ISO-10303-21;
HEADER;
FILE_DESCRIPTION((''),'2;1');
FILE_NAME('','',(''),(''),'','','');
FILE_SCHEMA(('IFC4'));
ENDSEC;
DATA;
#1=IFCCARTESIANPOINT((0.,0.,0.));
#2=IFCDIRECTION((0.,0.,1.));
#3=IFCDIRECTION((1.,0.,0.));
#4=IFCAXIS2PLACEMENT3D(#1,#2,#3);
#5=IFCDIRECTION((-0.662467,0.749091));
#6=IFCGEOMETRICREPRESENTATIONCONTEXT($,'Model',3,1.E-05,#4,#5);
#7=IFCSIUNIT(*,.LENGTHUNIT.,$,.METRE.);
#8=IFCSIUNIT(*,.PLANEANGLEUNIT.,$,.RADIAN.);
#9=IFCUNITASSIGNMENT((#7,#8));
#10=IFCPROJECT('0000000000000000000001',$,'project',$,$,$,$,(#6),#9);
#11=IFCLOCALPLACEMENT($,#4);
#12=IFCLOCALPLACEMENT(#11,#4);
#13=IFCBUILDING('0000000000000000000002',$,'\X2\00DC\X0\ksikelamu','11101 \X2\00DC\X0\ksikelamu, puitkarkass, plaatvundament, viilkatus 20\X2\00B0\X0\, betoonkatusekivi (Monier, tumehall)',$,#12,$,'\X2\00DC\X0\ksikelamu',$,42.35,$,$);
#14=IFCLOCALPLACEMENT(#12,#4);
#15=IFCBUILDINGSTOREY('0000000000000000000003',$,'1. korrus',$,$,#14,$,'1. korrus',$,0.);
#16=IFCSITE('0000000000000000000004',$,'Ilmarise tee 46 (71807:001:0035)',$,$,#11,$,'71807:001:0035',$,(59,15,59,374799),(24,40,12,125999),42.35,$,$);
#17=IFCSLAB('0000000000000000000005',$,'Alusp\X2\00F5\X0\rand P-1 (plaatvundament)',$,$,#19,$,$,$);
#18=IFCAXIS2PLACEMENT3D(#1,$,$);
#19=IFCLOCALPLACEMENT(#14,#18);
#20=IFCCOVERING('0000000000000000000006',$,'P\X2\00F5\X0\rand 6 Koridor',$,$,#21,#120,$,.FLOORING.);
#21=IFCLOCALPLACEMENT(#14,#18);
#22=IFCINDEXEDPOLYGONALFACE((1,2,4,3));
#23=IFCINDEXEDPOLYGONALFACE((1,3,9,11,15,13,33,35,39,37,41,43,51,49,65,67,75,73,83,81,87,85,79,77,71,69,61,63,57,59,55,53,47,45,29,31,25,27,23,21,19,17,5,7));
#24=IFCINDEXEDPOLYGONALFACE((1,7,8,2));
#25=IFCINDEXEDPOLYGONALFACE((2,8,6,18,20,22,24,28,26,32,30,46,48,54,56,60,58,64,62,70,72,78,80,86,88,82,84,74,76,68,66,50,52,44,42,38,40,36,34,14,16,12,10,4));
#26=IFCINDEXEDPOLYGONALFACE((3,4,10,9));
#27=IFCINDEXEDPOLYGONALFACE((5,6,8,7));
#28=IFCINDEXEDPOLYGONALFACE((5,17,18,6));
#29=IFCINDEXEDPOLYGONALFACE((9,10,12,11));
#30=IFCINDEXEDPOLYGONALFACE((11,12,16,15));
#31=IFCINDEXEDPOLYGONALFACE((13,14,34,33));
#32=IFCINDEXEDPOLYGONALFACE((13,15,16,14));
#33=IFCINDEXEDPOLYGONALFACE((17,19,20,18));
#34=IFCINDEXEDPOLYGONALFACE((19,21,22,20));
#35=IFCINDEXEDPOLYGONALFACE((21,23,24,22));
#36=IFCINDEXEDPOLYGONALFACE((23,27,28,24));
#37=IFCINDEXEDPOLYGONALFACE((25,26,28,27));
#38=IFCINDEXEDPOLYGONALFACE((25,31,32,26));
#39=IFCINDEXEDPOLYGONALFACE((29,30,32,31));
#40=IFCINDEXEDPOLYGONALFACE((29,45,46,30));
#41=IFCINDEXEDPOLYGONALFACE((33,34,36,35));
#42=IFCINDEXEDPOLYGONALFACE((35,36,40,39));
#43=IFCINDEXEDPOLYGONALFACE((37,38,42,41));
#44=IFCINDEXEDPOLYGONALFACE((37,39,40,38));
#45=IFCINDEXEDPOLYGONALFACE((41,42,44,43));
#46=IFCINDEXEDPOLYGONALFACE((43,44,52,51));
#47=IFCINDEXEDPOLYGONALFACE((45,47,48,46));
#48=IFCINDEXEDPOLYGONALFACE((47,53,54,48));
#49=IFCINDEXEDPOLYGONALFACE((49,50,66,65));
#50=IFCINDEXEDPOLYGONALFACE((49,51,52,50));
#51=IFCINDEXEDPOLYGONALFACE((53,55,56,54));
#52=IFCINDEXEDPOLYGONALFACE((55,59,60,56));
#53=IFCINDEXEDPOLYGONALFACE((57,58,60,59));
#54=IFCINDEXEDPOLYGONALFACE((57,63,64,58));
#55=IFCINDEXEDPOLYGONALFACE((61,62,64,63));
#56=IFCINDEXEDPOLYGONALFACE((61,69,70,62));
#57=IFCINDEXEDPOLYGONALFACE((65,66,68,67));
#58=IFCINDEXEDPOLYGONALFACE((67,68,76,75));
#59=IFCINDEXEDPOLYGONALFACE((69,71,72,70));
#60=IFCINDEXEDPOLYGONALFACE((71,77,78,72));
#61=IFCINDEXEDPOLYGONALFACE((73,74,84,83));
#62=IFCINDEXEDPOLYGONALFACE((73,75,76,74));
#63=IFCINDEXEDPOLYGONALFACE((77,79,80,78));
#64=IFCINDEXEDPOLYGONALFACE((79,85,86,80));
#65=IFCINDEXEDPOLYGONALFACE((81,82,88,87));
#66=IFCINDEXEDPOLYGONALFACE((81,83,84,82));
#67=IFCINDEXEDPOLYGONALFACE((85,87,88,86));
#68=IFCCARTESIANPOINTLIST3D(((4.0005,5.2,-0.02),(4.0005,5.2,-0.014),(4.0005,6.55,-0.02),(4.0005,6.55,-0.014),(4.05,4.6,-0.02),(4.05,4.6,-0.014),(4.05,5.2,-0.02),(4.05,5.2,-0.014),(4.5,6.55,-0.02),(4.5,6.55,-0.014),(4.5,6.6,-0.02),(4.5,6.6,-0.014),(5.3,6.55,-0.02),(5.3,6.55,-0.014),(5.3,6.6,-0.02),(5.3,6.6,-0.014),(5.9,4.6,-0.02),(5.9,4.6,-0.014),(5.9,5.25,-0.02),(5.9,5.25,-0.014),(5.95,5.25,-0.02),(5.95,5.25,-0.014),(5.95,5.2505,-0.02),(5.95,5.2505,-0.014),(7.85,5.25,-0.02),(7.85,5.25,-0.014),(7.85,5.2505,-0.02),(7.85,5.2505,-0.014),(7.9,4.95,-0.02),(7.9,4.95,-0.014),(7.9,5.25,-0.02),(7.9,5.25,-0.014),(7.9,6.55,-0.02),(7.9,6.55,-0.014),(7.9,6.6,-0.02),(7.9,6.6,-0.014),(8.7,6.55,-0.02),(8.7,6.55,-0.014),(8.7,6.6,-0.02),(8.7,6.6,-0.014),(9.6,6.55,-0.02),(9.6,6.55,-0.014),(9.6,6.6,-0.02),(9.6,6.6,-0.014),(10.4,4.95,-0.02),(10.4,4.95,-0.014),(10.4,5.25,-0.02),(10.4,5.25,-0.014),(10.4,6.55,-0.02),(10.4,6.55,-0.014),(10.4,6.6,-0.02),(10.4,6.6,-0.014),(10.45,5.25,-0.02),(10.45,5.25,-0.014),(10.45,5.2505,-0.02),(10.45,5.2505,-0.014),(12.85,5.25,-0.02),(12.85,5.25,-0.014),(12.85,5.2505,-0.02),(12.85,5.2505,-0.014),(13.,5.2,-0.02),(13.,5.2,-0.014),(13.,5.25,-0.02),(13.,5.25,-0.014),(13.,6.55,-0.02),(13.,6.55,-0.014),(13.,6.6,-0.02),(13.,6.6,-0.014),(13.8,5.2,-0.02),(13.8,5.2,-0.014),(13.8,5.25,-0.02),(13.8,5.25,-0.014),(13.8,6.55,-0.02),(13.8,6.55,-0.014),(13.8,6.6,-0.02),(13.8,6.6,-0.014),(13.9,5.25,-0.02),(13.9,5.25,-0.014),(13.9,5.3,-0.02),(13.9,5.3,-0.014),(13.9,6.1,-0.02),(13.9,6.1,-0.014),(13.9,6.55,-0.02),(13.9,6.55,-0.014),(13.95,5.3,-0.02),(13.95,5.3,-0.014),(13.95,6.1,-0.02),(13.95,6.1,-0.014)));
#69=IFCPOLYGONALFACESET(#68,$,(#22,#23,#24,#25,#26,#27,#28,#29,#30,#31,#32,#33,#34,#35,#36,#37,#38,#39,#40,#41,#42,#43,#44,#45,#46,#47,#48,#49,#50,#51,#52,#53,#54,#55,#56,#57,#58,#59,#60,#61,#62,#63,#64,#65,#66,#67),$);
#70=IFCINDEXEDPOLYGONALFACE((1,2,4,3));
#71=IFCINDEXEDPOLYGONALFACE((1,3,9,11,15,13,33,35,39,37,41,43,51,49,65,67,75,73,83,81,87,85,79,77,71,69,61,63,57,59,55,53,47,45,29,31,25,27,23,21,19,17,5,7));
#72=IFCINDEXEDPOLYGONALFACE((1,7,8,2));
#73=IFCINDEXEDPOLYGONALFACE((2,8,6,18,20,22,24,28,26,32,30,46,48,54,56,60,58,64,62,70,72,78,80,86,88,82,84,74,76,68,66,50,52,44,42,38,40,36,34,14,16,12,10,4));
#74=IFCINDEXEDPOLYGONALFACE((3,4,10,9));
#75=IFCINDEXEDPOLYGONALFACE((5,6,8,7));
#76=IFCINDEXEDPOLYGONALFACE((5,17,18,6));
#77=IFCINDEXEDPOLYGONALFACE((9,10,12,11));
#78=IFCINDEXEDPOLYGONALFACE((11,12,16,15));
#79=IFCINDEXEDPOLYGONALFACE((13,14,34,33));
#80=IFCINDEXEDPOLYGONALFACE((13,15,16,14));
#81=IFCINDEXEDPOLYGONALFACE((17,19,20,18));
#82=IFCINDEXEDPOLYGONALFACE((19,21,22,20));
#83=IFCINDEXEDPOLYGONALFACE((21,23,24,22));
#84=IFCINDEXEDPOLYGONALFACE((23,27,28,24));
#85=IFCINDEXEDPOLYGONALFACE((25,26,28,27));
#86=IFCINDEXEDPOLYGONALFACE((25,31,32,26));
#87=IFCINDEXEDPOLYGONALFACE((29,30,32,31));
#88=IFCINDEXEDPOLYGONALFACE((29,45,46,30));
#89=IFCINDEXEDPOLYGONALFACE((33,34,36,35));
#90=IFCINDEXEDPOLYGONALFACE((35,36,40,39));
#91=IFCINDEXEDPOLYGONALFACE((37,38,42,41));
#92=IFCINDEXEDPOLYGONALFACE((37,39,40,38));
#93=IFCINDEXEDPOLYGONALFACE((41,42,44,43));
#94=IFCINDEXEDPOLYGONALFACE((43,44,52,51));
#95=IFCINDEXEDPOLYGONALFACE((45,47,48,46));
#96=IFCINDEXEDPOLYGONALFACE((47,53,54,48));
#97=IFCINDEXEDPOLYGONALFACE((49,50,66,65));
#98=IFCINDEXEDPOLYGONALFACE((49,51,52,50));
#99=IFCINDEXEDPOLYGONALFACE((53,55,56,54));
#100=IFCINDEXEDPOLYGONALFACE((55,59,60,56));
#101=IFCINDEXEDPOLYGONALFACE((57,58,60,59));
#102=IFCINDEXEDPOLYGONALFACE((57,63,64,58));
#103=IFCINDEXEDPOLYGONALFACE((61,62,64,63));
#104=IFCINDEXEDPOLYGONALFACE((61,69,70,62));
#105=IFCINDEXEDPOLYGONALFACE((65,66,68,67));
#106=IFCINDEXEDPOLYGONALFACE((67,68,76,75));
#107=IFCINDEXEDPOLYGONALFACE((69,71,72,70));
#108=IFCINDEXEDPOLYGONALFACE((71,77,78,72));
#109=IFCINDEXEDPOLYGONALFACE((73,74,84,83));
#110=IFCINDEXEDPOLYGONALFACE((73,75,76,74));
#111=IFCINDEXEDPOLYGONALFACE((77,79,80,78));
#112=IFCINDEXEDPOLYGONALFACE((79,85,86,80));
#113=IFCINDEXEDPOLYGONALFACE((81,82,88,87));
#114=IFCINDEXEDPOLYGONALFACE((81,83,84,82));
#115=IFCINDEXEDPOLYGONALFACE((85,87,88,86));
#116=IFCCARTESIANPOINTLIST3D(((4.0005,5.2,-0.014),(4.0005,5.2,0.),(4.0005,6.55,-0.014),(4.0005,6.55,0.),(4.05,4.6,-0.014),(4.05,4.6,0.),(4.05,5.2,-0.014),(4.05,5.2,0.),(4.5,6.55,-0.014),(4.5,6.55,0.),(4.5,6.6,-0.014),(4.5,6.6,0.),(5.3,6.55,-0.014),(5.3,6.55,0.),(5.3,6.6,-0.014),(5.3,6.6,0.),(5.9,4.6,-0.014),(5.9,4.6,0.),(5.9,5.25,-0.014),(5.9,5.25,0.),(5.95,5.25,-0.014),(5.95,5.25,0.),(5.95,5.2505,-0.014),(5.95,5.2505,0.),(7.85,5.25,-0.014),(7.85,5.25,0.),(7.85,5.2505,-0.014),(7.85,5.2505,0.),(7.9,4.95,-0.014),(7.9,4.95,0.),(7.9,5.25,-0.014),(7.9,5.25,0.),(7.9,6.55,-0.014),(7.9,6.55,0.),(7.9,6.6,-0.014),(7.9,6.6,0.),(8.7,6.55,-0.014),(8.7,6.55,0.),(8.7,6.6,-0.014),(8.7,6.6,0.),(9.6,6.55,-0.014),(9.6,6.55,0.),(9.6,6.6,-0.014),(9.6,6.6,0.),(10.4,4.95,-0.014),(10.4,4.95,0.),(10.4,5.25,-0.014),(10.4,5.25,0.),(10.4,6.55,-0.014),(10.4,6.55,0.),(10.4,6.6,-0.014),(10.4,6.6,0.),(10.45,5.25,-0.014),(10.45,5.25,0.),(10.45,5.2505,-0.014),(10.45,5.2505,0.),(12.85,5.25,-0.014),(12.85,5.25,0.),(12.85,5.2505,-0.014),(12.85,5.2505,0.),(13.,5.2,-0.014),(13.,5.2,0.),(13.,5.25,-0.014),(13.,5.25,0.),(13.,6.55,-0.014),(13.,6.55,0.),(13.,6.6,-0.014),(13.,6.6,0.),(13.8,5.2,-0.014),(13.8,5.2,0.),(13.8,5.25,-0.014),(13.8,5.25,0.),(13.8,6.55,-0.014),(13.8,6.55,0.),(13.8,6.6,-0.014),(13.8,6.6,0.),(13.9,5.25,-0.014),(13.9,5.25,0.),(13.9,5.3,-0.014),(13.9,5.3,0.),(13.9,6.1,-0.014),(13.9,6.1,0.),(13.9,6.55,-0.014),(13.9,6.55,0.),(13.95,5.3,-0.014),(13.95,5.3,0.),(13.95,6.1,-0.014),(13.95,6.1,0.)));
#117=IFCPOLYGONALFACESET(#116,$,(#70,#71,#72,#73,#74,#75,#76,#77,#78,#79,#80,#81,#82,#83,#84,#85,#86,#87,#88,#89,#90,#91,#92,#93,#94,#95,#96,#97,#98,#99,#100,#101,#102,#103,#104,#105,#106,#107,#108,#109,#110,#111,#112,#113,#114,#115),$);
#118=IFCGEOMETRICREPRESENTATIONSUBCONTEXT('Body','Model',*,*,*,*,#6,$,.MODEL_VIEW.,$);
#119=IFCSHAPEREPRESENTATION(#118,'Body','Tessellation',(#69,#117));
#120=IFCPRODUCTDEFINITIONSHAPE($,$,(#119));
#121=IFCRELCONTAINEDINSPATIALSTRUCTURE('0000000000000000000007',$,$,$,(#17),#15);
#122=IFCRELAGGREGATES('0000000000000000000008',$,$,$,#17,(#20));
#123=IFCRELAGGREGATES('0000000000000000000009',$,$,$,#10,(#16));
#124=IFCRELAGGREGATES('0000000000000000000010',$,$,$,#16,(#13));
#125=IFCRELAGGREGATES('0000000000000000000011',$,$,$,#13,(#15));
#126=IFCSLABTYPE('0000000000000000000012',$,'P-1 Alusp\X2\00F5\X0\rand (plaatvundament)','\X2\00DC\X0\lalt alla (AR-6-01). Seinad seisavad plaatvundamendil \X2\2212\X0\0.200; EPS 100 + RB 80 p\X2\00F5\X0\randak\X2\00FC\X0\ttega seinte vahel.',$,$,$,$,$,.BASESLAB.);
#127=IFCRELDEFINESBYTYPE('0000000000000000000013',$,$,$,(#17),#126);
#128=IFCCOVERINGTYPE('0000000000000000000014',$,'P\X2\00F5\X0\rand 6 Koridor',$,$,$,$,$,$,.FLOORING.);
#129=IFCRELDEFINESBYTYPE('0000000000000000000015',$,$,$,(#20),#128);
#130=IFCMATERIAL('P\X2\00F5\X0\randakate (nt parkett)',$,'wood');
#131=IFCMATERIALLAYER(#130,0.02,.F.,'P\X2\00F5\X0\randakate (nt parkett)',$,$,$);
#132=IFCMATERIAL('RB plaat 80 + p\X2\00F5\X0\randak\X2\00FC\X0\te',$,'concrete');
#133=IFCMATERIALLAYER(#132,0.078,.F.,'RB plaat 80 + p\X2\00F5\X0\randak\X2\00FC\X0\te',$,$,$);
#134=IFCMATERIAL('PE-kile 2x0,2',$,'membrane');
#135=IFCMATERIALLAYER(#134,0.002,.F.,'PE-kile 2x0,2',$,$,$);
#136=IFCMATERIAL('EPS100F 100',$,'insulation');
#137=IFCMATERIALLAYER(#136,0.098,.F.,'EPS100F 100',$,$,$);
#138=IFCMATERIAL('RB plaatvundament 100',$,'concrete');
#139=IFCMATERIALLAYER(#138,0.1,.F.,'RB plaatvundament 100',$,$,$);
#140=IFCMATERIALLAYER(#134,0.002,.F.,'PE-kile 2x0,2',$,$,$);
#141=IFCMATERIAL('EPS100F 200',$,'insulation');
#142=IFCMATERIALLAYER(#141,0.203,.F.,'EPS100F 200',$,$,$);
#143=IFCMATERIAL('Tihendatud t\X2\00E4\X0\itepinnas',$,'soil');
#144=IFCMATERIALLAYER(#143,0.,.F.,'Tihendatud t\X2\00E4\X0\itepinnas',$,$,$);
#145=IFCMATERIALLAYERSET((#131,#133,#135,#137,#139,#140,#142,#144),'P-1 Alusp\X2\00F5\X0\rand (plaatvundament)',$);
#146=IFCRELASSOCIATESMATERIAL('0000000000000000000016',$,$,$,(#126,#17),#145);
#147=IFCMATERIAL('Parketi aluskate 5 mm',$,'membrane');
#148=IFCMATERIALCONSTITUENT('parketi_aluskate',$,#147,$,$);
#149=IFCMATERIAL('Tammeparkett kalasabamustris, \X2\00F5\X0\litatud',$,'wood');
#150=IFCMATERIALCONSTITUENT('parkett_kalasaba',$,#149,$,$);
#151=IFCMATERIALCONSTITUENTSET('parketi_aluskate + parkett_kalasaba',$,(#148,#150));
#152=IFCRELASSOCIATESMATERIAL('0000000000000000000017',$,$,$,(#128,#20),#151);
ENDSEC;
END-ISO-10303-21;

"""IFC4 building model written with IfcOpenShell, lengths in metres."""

from ifc_helpers import new_model, si_unit, direction, frame, origin_with_axes, place, context, subcontext, project, spatial, indexed_curve, outline, extrude, material, layer, layer_set, layer_usage, constituent, constituent_set, type_object, element, aggregate, save


model = new_model("IFC4")

# Units and contexts
model_context = context("Model", 3, precision=1e-05, world=origin_with_axes(), true_north=direction((-0.662467, 0.749091)))
body_context = subcontext(model_context, "Body", "Model", "MODEL_VIEW")
ifc_project = project(units=[si_unit("LENGTHUNIT", "METRE"), si_unit("PLANEANGLEUNIT", "RADIAN")], contexts=[model_context])

# Site, building, storey
site_placement = place(None, origin_with_axes())
site = spatial("IfcSite", under=ifc_project, at=site_placement, Name="Ilmarise tee 46 (71807:001:0035)", LongName="71807:001:0035", RefLatitude=(59, 15, 59, 374799), RefLongitude=(24, 40, 12, 125999), RefElevation=42.35)
building_placement = place(site_placement, origin_with_axes())
building = spatial("IfcBuilding", under=site, at=building_placement, Name="Üksikelamu", Description="11101 Üksikelamu, puitkarkass, plaatvundament, viilkatus 20°, betoonkatusekivi (Monier, tumehall)", LongName="Üksikelamu", ElevationOfRefHeight=42.35)
storey_placement = place(building_placement, origin_with_axes())
storey = spatial("IfcBuildingStorey", under=building, at=storey_placement, Name="1. korrus", LongName="1. korrus", Elevation=0.0)

# Slab
ifc_material_1 = material(Name="Põrandakate (nt parkett)", Category="wood")
ifc_layer_1 = layer(ifc_material_1, 0.02, ventilated=False, Name="Põrandakate (nt parkett)")
ifc_material_2 = material(Name="RB plaat 80 + põrandaküte", Category="concrete")
ifc_layer_2 = layer(ifc_material_2, 0.078, ventilated=False, Name="RB plaat 80 + põrandaküte")
ifc_material_3 = material(Name="PE-kile 2x0,2", Category="membrane")
ifc_layer_3 = layer(ifc_material_3, 0.002, ventilated=False, Name="PE-kile 2x0,2")
ifc_material_4 = material(Name="EPS100F 100", Category="insulation")
ifc_layer_4 = layer(ifc_material_4, 0.098, ventilated=False, Name="EPS100F 100")
ifc_material_5 = material(Name="RB plaatvundament 100", Category="concrete")
ifc_layer_5 = layer(ifc_material_5, 0.1, ventilated=False, Name="RB plaatvundament 100")
ifc_layer_6 = layer(ifc_material_3, 0.002, ventilated=False, Name="PE-kile 2x0,2")
ifc_material_6 = material(Name="EPS100F 200", Category="insulation")
ifc_layer_7 = layer(ifc_material_6, 0.203, ventilated=False, Name="EPS100F 200")
ifc_material_7 = material(Name="Tihendatud täitepinnas", Category="soil")
ifc_layer_8 = layer(ifc_material_7, 0.0, ventilated=False, Name="Tihendatud täitepinnas")
ifc_layer_set_1 = layer_set([ifc_layer_1, ifc_layer_2, ifc_layer_3, ifc_layer_4, ifc_layer_5, ifc_layer_6, ifc_layer_7, ifc_layer_8], Name="P-1 Aluspõrand (plaatvundament)")
ifc_layer_usage_1 = layer_usage(ifc_layer_set_1, "AXIS3", "NEGATIVE", 0.0)
slab_type = type_object("IfcSlabType", Name="P-1 Aluspõrand (plaatvundament)", Description="Ülalt alla (AR-6-01). Seinad seisavad plaatvundamendil −0.200; EPS 100 + RB 80 põrandaküttega seinte vahel.", PredefinedType="BASESLAB", material=ifc_layer_set_1)
slab_placement = place(storey_placement, origin_with_axes())
slab = element("IfcSlab", 1, at=slab_placement, inside=storey, type_object=slab_type, material=ifc_layer_usage_1, Name="Aluspõrand P-1 (plaatvundament)")
ifc_material_8 = material(Name="Parketi aluskate 5 mm", Category="membrane")
ifc_constituent_1 = constituent(ifc_material_8, Name="parketi_aluskate")
ifc_material_9 = material(Name="Tammeparkett kalasabamustris, õlitatud", Category="wood")
ifc_constituent_2 = constituent(ifc_material_9, Name="parkett_kalasaba")
ifc_constituent_set_1 = constituent_set(constituents=[ifc_constituent_1, ifc_constituent_2], Name="parketi_aluskate + parkett_kalasaba")

# Covering
covering_type_1 = type_object("IfcCoveringType", Name="Põrand 6 Koridor", PredefinedType="FLOORING", material=ifc_constituent_set_1)
covering_1_placement = place(slab_placement, origin_with_axes())
covering_1 = element("IfcCovering", 2, at=covering_1_placement, type_object=covering_type_1, material=ifc_constituent_set_1, Name="Põrand 6 Koridor", PredefinedType="FLOORING", context=body_context, shape_type="SweptSolid", body=[
    extrude(outline(indexed_curve([(4.5, 6.55), (4.5, 6.6), (5.3, 6.6), (5.3, 6.55), (7.9, 6.55), (7.9, 6.6), (8.7, 6.6), (8.7, 6.55), (9.6, 6.55), (9.6, 6.6), (10.4, 6.6), (10.4, 6.55), (13.0, 6.55), (13.0, 6.6), (13.8, 6.6), (13.8, 6.55), (13.9, 6.55), (13.9, 6.1), (13.95, 6.1), (13.95, 5.3), (13.9, 5.3), (13.9, 5.25), (13.8, 5.25), (13.8, 5.2), (13.0, 5.2), (13.0, 5.25), (12.85, 5.25), (12.85, 5.2505), (10.45, 5.2505), (10.45, 5.25), (10.4, 5.25), (10.4, 4.95), (7.9, 4.95), (7.9, 5.25), (7.85, 5.25), (7.85, 5.2505), (5.95, 5.2505), (5.95, 5.25), (5.9, 5.25), (5.9, 4.6), (4.05, 4.6), (4.05, 5.2), (4.0005, 5.2), (4.0005, 6.55), (4.5, 6.55)], self_intersect=False)), frame((0.0, 0.0, -0.02), z_axis=(0.0, 0.0, 1.0), x_axis=(1.0, 0.0, 0.0)), (0.0, 0.0, 1.0), 0.006),
    extrude(outline(indexed_curve([(4.5, 6.55), (4.5, 6.6), (5.3, 6.6), (5.3, 6.55), (7.9, 6.55), (7.9, 6.6), (8.7, 6.6), (8.7, 6.55), (9.6, 6.55), (9.6, 6.6), (10.4, 6.6), (10.4, 6.55), (13.0, 6.55), (13.0, 6.6), (13.8, 6.6), (13.8, 6.55), (13.9, 6.55), (13.9, 6.1), (13.95, 6.1), (13.95, 5.3), (13.9, 5.3), (13.9, 5.25), (13.8, 5.25), (13.8, 5.2), (13.0, 5.2), (13.0, 5.25), (12.85, 5.25), (12.85, 5.2505), (10.45, 5.2505), (10.45, 5.25), (10.4, 5.25), (10.4, 4.95), (7.9, 4.95), (7.9, 5.25), (7.85, 5.25), (7.85, 5.2505), (5.95, 5.2505), (5.95, 5.25), (5.9, 5.25), (5.9, 4.6), (4.05, 4.6), (4.05, 5.2), (4.0005, 5.2), (4.0005, 6.55), (4.5, 6.55)], self_intersect=False)), frame((0.0, 0.0, -0.014), z_axis=(0.0, 0.0, 1.0), x_axis=(1.0, 0.0, 0.0)), (0.0, 0.0, 1.0), 0.014),
])

aggregate(slab, [covering_1])

save(model, "model.ifc")
